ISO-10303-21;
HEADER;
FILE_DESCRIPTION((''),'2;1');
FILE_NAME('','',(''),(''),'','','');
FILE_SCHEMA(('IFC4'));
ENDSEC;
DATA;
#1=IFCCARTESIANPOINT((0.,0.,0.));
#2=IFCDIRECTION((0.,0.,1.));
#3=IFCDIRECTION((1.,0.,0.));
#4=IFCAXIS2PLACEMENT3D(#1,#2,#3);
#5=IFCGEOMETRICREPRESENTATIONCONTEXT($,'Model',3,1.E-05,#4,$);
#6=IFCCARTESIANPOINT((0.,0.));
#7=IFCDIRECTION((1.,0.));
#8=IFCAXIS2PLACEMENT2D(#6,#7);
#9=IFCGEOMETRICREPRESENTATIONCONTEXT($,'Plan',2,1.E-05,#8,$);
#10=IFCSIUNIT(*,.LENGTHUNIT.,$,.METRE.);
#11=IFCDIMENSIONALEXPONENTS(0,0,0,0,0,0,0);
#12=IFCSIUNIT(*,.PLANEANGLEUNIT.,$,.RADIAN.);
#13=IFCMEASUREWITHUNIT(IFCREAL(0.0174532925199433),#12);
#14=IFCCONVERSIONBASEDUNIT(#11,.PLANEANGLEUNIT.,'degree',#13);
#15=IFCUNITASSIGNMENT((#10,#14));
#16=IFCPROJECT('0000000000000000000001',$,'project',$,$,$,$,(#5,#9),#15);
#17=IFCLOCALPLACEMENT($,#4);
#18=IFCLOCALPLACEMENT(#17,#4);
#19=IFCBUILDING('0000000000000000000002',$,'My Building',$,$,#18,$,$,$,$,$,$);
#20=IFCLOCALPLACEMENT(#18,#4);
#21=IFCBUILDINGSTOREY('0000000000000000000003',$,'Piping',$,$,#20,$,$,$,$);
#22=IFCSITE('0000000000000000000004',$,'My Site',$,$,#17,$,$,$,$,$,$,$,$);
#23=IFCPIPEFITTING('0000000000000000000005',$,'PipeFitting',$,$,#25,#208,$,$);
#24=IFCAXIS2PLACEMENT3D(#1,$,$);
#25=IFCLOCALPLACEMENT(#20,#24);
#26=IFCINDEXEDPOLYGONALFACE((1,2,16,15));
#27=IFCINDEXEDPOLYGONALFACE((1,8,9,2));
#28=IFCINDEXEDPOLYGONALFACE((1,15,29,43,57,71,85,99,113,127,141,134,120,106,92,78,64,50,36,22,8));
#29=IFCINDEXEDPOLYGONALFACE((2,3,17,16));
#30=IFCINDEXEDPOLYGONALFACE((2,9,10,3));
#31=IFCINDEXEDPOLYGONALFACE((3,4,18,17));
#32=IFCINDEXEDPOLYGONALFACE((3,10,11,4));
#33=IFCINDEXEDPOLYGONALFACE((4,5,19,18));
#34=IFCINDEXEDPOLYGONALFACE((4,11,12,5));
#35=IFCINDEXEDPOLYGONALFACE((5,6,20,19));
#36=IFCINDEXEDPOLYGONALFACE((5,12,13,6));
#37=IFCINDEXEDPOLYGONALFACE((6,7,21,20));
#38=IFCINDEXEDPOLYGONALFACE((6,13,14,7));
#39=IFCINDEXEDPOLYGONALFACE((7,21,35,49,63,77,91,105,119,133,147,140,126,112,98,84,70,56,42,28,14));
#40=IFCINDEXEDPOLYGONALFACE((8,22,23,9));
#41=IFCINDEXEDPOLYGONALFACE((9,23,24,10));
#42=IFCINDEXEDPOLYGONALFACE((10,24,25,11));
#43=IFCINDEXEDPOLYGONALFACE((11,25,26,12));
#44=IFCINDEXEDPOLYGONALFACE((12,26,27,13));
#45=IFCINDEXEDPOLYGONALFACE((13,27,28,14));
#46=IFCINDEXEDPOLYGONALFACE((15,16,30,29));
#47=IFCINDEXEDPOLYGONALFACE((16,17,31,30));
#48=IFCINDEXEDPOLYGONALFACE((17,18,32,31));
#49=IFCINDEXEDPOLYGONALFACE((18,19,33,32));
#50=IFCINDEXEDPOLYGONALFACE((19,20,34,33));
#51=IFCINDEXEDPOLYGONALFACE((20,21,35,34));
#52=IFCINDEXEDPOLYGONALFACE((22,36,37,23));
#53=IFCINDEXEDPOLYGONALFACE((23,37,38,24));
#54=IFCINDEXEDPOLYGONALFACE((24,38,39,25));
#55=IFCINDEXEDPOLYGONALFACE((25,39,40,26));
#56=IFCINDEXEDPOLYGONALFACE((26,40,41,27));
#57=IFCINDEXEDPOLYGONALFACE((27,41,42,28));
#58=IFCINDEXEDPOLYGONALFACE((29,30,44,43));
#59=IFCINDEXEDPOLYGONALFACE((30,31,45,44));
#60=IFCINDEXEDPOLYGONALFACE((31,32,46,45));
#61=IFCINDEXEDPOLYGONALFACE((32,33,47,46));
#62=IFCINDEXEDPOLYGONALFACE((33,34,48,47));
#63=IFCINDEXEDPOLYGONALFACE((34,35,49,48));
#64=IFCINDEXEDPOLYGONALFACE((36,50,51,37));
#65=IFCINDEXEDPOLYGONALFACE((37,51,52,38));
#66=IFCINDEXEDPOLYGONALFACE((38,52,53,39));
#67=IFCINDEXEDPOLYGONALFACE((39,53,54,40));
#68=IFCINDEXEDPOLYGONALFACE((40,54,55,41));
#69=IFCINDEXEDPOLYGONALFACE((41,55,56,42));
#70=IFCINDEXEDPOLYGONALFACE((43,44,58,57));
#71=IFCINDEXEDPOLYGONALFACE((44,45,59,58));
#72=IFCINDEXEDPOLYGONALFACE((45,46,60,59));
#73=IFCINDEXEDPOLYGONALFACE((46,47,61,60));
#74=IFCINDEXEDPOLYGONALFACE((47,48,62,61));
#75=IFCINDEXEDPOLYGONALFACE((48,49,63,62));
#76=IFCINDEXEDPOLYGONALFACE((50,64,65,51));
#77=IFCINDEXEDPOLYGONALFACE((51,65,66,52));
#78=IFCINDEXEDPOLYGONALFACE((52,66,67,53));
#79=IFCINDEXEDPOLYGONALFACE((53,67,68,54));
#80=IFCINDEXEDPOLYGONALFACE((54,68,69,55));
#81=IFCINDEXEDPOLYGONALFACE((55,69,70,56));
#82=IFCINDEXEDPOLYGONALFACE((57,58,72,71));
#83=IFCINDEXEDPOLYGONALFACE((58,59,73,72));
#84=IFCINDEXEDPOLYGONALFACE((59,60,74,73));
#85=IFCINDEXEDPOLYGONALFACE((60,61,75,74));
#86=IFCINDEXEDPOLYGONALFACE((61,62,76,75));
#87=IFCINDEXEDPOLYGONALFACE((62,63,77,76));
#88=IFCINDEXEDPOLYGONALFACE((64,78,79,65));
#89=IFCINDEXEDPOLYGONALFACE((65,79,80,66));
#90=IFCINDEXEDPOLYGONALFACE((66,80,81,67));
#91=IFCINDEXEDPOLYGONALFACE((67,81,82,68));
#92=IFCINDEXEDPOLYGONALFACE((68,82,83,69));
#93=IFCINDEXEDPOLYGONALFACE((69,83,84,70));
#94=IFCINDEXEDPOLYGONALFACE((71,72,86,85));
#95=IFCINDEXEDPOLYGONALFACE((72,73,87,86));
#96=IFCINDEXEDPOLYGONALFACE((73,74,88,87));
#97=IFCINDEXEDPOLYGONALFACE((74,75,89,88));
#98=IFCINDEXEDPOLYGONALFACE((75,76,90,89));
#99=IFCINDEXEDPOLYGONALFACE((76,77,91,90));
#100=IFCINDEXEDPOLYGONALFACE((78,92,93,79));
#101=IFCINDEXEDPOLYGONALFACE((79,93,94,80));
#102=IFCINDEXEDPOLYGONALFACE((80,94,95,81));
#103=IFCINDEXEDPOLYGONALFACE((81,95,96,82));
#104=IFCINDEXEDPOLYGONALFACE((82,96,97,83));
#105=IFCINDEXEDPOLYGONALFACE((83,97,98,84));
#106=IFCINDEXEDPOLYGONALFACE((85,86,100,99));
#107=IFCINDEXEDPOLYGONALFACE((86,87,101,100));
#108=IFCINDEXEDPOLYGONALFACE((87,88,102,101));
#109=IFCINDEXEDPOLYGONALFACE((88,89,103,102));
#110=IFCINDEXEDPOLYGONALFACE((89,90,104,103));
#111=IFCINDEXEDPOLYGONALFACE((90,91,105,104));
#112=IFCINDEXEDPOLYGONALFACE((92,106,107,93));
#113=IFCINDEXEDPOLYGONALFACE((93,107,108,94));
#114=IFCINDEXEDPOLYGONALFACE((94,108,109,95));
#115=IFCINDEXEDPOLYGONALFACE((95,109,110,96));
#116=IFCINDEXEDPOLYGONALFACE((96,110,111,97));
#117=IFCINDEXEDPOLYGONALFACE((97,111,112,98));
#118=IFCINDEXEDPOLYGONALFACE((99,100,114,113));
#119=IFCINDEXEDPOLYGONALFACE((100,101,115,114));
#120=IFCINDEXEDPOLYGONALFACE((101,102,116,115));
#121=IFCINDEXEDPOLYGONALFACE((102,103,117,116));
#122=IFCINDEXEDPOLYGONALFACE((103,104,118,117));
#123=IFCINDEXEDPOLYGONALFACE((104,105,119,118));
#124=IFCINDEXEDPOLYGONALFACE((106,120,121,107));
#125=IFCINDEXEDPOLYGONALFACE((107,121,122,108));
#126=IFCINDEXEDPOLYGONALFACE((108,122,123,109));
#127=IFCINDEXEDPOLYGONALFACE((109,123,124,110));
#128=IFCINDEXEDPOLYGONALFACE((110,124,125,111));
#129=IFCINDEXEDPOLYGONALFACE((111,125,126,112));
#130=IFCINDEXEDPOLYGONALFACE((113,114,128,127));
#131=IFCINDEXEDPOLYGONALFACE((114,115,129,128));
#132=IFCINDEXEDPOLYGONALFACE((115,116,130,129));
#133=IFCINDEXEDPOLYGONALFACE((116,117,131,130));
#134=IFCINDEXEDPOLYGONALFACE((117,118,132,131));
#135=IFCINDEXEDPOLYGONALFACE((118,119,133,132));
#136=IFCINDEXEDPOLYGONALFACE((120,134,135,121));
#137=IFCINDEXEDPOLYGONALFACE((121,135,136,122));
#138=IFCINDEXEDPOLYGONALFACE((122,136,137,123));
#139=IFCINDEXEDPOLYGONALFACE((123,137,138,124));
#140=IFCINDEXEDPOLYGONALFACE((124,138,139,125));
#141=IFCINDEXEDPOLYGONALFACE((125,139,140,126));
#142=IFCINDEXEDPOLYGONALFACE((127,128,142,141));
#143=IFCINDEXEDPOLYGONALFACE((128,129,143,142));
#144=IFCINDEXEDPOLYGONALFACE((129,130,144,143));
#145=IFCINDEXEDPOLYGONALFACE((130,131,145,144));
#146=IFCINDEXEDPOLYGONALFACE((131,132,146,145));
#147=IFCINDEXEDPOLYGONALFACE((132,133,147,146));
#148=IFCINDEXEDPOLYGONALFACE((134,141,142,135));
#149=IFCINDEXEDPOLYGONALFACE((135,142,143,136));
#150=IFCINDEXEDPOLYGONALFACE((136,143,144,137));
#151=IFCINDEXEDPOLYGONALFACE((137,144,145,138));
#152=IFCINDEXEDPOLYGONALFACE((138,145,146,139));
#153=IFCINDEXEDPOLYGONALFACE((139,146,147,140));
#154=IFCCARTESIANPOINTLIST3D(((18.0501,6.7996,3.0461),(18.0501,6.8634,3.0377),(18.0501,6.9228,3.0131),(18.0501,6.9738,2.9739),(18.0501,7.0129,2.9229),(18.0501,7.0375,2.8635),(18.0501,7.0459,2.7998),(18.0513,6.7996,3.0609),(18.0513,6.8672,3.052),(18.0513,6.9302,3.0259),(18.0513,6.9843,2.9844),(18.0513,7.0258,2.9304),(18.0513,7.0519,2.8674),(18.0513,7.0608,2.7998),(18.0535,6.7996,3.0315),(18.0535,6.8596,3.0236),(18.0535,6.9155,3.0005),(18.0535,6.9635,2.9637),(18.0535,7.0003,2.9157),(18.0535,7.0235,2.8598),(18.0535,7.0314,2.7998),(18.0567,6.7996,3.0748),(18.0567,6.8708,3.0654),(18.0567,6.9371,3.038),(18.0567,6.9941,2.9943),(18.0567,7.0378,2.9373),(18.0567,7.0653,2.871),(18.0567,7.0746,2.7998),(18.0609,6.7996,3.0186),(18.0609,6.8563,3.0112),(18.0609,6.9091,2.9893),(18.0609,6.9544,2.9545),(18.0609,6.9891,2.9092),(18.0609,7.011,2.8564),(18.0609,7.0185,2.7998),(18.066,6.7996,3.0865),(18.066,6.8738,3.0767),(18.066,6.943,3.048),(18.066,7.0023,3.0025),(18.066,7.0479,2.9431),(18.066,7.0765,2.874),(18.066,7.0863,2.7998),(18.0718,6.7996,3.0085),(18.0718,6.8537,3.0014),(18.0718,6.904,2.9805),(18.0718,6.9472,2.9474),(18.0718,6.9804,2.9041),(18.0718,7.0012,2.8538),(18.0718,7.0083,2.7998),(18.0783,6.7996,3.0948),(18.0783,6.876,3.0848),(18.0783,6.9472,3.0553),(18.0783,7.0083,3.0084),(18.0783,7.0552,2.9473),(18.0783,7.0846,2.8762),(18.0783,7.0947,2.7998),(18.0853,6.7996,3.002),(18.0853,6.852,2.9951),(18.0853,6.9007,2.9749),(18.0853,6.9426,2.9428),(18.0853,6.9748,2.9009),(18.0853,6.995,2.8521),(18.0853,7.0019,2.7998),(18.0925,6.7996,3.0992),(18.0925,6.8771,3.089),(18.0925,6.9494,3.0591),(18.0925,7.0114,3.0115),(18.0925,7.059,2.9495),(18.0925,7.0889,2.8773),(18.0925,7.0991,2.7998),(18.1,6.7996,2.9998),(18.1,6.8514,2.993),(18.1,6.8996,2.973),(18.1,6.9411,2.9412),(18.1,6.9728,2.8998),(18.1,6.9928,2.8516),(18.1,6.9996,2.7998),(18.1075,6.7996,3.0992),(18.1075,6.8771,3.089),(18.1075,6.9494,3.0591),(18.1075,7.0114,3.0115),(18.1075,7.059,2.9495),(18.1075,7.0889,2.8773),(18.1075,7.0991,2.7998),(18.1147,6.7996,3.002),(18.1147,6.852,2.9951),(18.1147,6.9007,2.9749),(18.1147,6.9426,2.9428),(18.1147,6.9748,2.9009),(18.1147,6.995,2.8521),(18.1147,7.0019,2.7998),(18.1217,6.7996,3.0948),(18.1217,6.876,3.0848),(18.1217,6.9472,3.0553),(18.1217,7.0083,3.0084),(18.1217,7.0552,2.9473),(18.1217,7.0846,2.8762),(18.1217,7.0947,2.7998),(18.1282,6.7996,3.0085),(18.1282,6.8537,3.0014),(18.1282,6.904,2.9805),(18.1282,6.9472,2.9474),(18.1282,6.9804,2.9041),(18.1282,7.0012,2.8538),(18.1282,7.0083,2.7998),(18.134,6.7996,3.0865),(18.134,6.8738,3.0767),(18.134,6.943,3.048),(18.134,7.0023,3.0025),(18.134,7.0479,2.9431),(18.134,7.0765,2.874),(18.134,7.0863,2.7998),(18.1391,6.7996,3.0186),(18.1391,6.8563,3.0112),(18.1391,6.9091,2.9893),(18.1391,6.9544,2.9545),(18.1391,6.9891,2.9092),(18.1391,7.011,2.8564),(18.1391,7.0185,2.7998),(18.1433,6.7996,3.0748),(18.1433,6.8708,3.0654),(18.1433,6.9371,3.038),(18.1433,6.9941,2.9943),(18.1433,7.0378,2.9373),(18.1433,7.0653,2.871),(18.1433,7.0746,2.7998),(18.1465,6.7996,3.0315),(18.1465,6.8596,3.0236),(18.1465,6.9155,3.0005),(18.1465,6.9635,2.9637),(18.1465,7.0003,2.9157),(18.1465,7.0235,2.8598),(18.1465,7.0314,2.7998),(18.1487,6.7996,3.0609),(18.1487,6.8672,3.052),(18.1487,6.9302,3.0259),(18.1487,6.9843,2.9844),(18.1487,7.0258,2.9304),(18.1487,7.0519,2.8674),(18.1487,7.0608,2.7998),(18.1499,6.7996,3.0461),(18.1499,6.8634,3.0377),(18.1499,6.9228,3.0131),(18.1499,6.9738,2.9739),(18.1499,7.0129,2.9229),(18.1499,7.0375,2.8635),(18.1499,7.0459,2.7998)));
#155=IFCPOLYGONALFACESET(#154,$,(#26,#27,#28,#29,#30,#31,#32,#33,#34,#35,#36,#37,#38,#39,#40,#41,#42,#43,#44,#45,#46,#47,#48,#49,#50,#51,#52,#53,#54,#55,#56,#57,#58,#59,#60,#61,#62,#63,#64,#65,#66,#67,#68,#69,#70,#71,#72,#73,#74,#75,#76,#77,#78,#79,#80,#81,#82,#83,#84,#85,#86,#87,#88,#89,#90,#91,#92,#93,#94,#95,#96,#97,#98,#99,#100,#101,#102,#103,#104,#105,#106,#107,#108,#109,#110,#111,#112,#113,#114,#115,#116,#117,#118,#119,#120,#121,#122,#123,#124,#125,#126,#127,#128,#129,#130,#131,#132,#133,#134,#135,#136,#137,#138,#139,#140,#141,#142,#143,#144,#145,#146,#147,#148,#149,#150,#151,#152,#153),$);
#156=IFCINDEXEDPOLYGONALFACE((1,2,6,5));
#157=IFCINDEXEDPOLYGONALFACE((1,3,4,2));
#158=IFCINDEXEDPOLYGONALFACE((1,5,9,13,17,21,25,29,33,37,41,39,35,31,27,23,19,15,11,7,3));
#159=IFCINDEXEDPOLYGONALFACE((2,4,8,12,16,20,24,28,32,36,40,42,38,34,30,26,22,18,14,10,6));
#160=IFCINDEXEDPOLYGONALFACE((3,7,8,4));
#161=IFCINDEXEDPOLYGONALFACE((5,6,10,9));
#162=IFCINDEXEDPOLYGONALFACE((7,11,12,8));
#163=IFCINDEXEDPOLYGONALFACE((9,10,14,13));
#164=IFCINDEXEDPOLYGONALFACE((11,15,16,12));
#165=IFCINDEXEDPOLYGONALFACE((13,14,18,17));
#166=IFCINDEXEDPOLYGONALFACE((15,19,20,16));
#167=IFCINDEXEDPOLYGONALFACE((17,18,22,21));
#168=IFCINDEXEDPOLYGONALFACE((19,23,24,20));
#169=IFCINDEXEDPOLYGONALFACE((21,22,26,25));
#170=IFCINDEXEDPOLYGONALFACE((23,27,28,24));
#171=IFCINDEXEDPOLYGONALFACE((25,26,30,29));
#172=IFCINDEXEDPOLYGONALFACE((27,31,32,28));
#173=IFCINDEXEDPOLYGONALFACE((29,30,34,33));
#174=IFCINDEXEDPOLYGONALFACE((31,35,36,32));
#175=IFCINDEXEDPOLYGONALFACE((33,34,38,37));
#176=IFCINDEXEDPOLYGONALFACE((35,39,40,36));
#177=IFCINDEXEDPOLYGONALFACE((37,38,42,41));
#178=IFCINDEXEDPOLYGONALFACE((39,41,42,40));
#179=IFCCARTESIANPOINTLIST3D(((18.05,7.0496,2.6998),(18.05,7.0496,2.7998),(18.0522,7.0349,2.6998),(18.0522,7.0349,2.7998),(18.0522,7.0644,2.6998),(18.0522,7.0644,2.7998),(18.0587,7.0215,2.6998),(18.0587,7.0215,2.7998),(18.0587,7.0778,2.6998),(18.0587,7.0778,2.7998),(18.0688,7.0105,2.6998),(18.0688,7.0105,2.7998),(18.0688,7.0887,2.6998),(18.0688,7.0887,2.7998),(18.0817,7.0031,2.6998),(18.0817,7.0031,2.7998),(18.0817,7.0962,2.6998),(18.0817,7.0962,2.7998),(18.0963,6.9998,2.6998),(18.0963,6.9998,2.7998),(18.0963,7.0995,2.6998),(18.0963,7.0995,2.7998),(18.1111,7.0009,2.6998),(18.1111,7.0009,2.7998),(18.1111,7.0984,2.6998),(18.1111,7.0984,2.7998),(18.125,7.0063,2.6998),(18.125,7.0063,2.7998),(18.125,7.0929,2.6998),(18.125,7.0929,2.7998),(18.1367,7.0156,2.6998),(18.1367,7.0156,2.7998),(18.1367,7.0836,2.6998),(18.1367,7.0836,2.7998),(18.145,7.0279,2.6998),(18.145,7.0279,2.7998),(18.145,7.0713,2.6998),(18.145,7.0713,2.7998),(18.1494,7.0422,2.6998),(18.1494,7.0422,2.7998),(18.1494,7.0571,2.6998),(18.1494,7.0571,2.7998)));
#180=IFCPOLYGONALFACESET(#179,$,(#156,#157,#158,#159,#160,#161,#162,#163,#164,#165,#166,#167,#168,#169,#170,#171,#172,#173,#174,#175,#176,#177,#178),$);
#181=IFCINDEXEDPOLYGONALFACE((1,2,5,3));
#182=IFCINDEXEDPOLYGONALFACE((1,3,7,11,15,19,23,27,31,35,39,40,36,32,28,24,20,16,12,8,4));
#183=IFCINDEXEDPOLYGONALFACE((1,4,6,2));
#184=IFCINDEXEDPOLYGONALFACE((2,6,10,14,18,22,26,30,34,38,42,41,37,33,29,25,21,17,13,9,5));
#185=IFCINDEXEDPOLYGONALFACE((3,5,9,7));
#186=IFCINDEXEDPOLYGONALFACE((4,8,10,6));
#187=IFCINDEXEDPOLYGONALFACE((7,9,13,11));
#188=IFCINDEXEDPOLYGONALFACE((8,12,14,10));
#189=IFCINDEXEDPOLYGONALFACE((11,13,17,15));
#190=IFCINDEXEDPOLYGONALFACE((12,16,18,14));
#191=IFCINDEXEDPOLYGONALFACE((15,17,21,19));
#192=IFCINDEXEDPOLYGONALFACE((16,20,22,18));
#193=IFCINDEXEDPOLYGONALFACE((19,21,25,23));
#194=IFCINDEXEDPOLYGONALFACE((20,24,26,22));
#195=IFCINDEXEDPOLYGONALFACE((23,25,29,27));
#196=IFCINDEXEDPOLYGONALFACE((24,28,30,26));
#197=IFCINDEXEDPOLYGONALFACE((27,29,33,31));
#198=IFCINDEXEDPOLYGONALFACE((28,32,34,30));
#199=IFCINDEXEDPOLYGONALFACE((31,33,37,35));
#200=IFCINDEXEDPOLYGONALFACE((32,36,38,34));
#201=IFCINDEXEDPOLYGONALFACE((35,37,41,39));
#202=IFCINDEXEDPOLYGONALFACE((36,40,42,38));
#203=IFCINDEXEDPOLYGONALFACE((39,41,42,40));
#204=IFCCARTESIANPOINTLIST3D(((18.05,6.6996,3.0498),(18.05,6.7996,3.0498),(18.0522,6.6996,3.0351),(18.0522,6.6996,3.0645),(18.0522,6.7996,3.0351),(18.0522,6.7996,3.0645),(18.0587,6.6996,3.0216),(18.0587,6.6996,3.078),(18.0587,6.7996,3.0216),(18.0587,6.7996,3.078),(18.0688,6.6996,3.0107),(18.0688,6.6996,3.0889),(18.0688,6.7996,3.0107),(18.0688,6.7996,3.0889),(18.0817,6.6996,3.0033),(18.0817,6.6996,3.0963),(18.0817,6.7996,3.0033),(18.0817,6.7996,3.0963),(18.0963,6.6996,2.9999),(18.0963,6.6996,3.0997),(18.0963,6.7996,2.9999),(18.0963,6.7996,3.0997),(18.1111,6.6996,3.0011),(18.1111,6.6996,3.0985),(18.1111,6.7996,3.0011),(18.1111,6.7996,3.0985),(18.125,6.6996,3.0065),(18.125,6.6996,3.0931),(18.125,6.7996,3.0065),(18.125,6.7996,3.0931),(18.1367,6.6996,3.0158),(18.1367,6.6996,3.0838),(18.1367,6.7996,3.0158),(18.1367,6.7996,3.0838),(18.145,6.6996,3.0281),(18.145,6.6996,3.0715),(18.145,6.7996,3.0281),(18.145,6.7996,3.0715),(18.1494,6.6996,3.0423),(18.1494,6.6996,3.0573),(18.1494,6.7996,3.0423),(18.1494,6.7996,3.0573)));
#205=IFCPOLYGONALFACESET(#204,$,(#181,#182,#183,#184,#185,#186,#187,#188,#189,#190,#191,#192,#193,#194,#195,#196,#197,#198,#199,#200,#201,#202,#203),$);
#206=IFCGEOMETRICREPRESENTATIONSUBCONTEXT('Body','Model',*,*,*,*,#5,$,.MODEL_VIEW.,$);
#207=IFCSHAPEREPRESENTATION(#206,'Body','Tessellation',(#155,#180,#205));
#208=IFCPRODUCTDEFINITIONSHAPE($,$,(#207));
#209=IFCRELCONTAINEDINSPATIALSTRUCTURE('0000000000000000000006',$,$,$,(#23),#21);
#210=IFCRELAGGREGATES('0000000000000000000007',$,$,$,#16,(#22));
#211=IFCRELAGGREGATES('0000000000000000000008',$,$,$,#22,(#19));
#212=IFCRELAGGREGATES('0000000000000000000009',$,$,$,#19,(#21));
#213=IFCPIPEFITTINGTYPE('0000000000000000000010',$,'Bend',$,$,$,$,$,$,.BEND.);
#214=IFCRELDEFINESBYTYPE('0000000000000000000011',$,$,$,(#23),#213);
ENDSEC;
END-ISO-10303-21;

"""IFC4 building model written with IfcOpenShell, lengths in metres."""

from ifc_helpers import new_model, entity, si_unit, converted_unit, frame, origin_with_axes, origin_2d_with_axis, place, context, subcontext, project, spatial, circle, extrude, source, transform, mapped, type_object, type_shapes, element, save


model = new_model("IFC4")

# Units and contexts
model_context = context("Model", 3, precision=1e-05, world=origin_with_axes())
plan_context = context("Plan", 2, precision=1e-05, world=origin_2d_with_axis())
body_context = subcontext(model_context, "Body", "Model", "MODEL_VIEW")
ifc_project = project(units=[si_unit("LENGTHUNIT", "METRE"), converted_unit("PLANEANGLEUNIT", "degree", entity("IfcReal", 0.0174532925199433), si_unit("PLANEANGLEUNIT", "RADIAN"), dimensions=[0, 0, 0, 0, 0, 0, 0])], contexts=[model_context, plan_context])

# Site, building, storey
site_placement = place(None, origin_with_axes())
site = spatial("IfcSite", under=ifc_project, at=site_placement, Name="My Site")
building_placement = place(site_placement, origin_with_axes())
building = spatial("IfcBuilding", under=site, at=building_placement, Name="My Building")
storey_placement = place(building_placement, origin_with_axes())
storey = spatial("IfcBuildingStorey", under=building, at=storey_placement, Name="Piping")

# Pipe fitting
pipe_fitting_type_1 = type_object("IfcPipeFittingType", Name="Bend", PredefinedType="BEND")
shared_shape = source(origin_with_axes(), body_context, "Body", "SolidModel", [
    entity("IfcSweptDiskSolid", entity("IfcIndexedPolyCurve", entity("IfcCartesianPointList3D", [[0.0, 0.0, -0.1], [0.0, -0.0732, -0.2768], [0.0, -0.25, -0.35]]), [entity("IfcArcIndex", [1, 2, 3])]), 0.05),
    extrude(circle(Radius=0.05), origin_with_axes(), (0.0, 0.0, -1.0), 0.1),
    extrude(circle(Radius=0.05), frame((0.0, -0.25, -0.35), z_axis=(0.0, -1.0, 0.0), x_axis=(1.0, 0.0, 0.0)), (0.0, 0.0, 1.0), 0.1),
])
type_shapes(pipe_fitting_type_1, [shared_shape])
for number, where, z_axis, x_axis, name in (
    (1, (18.1, 7.0496, 2.6998), (0.0, 0.0, -1.0), (-1.0, 0.0, 0.0), "PipeFitting"),
):
    element("IfcPipeFitting", number, at=place(storey_placement, frame(where, z_axis=z_axis, x_axis=x_axis)), inside=storey, type_object=pipe_fitting_type_1, Name=name, context=body_context, shape_type="MappedRepresentation", body=[
        mapped(shared_shape, transform((0.0, 0.0, 0.0), x_axis=(1.0, 0.0, 0.0), y_axis=(0.0, 1.0, 0.0), z_axis=(0.0, 0.0, 1.0), scale=1.0)),
    ])

save(model, "model.ifc")
